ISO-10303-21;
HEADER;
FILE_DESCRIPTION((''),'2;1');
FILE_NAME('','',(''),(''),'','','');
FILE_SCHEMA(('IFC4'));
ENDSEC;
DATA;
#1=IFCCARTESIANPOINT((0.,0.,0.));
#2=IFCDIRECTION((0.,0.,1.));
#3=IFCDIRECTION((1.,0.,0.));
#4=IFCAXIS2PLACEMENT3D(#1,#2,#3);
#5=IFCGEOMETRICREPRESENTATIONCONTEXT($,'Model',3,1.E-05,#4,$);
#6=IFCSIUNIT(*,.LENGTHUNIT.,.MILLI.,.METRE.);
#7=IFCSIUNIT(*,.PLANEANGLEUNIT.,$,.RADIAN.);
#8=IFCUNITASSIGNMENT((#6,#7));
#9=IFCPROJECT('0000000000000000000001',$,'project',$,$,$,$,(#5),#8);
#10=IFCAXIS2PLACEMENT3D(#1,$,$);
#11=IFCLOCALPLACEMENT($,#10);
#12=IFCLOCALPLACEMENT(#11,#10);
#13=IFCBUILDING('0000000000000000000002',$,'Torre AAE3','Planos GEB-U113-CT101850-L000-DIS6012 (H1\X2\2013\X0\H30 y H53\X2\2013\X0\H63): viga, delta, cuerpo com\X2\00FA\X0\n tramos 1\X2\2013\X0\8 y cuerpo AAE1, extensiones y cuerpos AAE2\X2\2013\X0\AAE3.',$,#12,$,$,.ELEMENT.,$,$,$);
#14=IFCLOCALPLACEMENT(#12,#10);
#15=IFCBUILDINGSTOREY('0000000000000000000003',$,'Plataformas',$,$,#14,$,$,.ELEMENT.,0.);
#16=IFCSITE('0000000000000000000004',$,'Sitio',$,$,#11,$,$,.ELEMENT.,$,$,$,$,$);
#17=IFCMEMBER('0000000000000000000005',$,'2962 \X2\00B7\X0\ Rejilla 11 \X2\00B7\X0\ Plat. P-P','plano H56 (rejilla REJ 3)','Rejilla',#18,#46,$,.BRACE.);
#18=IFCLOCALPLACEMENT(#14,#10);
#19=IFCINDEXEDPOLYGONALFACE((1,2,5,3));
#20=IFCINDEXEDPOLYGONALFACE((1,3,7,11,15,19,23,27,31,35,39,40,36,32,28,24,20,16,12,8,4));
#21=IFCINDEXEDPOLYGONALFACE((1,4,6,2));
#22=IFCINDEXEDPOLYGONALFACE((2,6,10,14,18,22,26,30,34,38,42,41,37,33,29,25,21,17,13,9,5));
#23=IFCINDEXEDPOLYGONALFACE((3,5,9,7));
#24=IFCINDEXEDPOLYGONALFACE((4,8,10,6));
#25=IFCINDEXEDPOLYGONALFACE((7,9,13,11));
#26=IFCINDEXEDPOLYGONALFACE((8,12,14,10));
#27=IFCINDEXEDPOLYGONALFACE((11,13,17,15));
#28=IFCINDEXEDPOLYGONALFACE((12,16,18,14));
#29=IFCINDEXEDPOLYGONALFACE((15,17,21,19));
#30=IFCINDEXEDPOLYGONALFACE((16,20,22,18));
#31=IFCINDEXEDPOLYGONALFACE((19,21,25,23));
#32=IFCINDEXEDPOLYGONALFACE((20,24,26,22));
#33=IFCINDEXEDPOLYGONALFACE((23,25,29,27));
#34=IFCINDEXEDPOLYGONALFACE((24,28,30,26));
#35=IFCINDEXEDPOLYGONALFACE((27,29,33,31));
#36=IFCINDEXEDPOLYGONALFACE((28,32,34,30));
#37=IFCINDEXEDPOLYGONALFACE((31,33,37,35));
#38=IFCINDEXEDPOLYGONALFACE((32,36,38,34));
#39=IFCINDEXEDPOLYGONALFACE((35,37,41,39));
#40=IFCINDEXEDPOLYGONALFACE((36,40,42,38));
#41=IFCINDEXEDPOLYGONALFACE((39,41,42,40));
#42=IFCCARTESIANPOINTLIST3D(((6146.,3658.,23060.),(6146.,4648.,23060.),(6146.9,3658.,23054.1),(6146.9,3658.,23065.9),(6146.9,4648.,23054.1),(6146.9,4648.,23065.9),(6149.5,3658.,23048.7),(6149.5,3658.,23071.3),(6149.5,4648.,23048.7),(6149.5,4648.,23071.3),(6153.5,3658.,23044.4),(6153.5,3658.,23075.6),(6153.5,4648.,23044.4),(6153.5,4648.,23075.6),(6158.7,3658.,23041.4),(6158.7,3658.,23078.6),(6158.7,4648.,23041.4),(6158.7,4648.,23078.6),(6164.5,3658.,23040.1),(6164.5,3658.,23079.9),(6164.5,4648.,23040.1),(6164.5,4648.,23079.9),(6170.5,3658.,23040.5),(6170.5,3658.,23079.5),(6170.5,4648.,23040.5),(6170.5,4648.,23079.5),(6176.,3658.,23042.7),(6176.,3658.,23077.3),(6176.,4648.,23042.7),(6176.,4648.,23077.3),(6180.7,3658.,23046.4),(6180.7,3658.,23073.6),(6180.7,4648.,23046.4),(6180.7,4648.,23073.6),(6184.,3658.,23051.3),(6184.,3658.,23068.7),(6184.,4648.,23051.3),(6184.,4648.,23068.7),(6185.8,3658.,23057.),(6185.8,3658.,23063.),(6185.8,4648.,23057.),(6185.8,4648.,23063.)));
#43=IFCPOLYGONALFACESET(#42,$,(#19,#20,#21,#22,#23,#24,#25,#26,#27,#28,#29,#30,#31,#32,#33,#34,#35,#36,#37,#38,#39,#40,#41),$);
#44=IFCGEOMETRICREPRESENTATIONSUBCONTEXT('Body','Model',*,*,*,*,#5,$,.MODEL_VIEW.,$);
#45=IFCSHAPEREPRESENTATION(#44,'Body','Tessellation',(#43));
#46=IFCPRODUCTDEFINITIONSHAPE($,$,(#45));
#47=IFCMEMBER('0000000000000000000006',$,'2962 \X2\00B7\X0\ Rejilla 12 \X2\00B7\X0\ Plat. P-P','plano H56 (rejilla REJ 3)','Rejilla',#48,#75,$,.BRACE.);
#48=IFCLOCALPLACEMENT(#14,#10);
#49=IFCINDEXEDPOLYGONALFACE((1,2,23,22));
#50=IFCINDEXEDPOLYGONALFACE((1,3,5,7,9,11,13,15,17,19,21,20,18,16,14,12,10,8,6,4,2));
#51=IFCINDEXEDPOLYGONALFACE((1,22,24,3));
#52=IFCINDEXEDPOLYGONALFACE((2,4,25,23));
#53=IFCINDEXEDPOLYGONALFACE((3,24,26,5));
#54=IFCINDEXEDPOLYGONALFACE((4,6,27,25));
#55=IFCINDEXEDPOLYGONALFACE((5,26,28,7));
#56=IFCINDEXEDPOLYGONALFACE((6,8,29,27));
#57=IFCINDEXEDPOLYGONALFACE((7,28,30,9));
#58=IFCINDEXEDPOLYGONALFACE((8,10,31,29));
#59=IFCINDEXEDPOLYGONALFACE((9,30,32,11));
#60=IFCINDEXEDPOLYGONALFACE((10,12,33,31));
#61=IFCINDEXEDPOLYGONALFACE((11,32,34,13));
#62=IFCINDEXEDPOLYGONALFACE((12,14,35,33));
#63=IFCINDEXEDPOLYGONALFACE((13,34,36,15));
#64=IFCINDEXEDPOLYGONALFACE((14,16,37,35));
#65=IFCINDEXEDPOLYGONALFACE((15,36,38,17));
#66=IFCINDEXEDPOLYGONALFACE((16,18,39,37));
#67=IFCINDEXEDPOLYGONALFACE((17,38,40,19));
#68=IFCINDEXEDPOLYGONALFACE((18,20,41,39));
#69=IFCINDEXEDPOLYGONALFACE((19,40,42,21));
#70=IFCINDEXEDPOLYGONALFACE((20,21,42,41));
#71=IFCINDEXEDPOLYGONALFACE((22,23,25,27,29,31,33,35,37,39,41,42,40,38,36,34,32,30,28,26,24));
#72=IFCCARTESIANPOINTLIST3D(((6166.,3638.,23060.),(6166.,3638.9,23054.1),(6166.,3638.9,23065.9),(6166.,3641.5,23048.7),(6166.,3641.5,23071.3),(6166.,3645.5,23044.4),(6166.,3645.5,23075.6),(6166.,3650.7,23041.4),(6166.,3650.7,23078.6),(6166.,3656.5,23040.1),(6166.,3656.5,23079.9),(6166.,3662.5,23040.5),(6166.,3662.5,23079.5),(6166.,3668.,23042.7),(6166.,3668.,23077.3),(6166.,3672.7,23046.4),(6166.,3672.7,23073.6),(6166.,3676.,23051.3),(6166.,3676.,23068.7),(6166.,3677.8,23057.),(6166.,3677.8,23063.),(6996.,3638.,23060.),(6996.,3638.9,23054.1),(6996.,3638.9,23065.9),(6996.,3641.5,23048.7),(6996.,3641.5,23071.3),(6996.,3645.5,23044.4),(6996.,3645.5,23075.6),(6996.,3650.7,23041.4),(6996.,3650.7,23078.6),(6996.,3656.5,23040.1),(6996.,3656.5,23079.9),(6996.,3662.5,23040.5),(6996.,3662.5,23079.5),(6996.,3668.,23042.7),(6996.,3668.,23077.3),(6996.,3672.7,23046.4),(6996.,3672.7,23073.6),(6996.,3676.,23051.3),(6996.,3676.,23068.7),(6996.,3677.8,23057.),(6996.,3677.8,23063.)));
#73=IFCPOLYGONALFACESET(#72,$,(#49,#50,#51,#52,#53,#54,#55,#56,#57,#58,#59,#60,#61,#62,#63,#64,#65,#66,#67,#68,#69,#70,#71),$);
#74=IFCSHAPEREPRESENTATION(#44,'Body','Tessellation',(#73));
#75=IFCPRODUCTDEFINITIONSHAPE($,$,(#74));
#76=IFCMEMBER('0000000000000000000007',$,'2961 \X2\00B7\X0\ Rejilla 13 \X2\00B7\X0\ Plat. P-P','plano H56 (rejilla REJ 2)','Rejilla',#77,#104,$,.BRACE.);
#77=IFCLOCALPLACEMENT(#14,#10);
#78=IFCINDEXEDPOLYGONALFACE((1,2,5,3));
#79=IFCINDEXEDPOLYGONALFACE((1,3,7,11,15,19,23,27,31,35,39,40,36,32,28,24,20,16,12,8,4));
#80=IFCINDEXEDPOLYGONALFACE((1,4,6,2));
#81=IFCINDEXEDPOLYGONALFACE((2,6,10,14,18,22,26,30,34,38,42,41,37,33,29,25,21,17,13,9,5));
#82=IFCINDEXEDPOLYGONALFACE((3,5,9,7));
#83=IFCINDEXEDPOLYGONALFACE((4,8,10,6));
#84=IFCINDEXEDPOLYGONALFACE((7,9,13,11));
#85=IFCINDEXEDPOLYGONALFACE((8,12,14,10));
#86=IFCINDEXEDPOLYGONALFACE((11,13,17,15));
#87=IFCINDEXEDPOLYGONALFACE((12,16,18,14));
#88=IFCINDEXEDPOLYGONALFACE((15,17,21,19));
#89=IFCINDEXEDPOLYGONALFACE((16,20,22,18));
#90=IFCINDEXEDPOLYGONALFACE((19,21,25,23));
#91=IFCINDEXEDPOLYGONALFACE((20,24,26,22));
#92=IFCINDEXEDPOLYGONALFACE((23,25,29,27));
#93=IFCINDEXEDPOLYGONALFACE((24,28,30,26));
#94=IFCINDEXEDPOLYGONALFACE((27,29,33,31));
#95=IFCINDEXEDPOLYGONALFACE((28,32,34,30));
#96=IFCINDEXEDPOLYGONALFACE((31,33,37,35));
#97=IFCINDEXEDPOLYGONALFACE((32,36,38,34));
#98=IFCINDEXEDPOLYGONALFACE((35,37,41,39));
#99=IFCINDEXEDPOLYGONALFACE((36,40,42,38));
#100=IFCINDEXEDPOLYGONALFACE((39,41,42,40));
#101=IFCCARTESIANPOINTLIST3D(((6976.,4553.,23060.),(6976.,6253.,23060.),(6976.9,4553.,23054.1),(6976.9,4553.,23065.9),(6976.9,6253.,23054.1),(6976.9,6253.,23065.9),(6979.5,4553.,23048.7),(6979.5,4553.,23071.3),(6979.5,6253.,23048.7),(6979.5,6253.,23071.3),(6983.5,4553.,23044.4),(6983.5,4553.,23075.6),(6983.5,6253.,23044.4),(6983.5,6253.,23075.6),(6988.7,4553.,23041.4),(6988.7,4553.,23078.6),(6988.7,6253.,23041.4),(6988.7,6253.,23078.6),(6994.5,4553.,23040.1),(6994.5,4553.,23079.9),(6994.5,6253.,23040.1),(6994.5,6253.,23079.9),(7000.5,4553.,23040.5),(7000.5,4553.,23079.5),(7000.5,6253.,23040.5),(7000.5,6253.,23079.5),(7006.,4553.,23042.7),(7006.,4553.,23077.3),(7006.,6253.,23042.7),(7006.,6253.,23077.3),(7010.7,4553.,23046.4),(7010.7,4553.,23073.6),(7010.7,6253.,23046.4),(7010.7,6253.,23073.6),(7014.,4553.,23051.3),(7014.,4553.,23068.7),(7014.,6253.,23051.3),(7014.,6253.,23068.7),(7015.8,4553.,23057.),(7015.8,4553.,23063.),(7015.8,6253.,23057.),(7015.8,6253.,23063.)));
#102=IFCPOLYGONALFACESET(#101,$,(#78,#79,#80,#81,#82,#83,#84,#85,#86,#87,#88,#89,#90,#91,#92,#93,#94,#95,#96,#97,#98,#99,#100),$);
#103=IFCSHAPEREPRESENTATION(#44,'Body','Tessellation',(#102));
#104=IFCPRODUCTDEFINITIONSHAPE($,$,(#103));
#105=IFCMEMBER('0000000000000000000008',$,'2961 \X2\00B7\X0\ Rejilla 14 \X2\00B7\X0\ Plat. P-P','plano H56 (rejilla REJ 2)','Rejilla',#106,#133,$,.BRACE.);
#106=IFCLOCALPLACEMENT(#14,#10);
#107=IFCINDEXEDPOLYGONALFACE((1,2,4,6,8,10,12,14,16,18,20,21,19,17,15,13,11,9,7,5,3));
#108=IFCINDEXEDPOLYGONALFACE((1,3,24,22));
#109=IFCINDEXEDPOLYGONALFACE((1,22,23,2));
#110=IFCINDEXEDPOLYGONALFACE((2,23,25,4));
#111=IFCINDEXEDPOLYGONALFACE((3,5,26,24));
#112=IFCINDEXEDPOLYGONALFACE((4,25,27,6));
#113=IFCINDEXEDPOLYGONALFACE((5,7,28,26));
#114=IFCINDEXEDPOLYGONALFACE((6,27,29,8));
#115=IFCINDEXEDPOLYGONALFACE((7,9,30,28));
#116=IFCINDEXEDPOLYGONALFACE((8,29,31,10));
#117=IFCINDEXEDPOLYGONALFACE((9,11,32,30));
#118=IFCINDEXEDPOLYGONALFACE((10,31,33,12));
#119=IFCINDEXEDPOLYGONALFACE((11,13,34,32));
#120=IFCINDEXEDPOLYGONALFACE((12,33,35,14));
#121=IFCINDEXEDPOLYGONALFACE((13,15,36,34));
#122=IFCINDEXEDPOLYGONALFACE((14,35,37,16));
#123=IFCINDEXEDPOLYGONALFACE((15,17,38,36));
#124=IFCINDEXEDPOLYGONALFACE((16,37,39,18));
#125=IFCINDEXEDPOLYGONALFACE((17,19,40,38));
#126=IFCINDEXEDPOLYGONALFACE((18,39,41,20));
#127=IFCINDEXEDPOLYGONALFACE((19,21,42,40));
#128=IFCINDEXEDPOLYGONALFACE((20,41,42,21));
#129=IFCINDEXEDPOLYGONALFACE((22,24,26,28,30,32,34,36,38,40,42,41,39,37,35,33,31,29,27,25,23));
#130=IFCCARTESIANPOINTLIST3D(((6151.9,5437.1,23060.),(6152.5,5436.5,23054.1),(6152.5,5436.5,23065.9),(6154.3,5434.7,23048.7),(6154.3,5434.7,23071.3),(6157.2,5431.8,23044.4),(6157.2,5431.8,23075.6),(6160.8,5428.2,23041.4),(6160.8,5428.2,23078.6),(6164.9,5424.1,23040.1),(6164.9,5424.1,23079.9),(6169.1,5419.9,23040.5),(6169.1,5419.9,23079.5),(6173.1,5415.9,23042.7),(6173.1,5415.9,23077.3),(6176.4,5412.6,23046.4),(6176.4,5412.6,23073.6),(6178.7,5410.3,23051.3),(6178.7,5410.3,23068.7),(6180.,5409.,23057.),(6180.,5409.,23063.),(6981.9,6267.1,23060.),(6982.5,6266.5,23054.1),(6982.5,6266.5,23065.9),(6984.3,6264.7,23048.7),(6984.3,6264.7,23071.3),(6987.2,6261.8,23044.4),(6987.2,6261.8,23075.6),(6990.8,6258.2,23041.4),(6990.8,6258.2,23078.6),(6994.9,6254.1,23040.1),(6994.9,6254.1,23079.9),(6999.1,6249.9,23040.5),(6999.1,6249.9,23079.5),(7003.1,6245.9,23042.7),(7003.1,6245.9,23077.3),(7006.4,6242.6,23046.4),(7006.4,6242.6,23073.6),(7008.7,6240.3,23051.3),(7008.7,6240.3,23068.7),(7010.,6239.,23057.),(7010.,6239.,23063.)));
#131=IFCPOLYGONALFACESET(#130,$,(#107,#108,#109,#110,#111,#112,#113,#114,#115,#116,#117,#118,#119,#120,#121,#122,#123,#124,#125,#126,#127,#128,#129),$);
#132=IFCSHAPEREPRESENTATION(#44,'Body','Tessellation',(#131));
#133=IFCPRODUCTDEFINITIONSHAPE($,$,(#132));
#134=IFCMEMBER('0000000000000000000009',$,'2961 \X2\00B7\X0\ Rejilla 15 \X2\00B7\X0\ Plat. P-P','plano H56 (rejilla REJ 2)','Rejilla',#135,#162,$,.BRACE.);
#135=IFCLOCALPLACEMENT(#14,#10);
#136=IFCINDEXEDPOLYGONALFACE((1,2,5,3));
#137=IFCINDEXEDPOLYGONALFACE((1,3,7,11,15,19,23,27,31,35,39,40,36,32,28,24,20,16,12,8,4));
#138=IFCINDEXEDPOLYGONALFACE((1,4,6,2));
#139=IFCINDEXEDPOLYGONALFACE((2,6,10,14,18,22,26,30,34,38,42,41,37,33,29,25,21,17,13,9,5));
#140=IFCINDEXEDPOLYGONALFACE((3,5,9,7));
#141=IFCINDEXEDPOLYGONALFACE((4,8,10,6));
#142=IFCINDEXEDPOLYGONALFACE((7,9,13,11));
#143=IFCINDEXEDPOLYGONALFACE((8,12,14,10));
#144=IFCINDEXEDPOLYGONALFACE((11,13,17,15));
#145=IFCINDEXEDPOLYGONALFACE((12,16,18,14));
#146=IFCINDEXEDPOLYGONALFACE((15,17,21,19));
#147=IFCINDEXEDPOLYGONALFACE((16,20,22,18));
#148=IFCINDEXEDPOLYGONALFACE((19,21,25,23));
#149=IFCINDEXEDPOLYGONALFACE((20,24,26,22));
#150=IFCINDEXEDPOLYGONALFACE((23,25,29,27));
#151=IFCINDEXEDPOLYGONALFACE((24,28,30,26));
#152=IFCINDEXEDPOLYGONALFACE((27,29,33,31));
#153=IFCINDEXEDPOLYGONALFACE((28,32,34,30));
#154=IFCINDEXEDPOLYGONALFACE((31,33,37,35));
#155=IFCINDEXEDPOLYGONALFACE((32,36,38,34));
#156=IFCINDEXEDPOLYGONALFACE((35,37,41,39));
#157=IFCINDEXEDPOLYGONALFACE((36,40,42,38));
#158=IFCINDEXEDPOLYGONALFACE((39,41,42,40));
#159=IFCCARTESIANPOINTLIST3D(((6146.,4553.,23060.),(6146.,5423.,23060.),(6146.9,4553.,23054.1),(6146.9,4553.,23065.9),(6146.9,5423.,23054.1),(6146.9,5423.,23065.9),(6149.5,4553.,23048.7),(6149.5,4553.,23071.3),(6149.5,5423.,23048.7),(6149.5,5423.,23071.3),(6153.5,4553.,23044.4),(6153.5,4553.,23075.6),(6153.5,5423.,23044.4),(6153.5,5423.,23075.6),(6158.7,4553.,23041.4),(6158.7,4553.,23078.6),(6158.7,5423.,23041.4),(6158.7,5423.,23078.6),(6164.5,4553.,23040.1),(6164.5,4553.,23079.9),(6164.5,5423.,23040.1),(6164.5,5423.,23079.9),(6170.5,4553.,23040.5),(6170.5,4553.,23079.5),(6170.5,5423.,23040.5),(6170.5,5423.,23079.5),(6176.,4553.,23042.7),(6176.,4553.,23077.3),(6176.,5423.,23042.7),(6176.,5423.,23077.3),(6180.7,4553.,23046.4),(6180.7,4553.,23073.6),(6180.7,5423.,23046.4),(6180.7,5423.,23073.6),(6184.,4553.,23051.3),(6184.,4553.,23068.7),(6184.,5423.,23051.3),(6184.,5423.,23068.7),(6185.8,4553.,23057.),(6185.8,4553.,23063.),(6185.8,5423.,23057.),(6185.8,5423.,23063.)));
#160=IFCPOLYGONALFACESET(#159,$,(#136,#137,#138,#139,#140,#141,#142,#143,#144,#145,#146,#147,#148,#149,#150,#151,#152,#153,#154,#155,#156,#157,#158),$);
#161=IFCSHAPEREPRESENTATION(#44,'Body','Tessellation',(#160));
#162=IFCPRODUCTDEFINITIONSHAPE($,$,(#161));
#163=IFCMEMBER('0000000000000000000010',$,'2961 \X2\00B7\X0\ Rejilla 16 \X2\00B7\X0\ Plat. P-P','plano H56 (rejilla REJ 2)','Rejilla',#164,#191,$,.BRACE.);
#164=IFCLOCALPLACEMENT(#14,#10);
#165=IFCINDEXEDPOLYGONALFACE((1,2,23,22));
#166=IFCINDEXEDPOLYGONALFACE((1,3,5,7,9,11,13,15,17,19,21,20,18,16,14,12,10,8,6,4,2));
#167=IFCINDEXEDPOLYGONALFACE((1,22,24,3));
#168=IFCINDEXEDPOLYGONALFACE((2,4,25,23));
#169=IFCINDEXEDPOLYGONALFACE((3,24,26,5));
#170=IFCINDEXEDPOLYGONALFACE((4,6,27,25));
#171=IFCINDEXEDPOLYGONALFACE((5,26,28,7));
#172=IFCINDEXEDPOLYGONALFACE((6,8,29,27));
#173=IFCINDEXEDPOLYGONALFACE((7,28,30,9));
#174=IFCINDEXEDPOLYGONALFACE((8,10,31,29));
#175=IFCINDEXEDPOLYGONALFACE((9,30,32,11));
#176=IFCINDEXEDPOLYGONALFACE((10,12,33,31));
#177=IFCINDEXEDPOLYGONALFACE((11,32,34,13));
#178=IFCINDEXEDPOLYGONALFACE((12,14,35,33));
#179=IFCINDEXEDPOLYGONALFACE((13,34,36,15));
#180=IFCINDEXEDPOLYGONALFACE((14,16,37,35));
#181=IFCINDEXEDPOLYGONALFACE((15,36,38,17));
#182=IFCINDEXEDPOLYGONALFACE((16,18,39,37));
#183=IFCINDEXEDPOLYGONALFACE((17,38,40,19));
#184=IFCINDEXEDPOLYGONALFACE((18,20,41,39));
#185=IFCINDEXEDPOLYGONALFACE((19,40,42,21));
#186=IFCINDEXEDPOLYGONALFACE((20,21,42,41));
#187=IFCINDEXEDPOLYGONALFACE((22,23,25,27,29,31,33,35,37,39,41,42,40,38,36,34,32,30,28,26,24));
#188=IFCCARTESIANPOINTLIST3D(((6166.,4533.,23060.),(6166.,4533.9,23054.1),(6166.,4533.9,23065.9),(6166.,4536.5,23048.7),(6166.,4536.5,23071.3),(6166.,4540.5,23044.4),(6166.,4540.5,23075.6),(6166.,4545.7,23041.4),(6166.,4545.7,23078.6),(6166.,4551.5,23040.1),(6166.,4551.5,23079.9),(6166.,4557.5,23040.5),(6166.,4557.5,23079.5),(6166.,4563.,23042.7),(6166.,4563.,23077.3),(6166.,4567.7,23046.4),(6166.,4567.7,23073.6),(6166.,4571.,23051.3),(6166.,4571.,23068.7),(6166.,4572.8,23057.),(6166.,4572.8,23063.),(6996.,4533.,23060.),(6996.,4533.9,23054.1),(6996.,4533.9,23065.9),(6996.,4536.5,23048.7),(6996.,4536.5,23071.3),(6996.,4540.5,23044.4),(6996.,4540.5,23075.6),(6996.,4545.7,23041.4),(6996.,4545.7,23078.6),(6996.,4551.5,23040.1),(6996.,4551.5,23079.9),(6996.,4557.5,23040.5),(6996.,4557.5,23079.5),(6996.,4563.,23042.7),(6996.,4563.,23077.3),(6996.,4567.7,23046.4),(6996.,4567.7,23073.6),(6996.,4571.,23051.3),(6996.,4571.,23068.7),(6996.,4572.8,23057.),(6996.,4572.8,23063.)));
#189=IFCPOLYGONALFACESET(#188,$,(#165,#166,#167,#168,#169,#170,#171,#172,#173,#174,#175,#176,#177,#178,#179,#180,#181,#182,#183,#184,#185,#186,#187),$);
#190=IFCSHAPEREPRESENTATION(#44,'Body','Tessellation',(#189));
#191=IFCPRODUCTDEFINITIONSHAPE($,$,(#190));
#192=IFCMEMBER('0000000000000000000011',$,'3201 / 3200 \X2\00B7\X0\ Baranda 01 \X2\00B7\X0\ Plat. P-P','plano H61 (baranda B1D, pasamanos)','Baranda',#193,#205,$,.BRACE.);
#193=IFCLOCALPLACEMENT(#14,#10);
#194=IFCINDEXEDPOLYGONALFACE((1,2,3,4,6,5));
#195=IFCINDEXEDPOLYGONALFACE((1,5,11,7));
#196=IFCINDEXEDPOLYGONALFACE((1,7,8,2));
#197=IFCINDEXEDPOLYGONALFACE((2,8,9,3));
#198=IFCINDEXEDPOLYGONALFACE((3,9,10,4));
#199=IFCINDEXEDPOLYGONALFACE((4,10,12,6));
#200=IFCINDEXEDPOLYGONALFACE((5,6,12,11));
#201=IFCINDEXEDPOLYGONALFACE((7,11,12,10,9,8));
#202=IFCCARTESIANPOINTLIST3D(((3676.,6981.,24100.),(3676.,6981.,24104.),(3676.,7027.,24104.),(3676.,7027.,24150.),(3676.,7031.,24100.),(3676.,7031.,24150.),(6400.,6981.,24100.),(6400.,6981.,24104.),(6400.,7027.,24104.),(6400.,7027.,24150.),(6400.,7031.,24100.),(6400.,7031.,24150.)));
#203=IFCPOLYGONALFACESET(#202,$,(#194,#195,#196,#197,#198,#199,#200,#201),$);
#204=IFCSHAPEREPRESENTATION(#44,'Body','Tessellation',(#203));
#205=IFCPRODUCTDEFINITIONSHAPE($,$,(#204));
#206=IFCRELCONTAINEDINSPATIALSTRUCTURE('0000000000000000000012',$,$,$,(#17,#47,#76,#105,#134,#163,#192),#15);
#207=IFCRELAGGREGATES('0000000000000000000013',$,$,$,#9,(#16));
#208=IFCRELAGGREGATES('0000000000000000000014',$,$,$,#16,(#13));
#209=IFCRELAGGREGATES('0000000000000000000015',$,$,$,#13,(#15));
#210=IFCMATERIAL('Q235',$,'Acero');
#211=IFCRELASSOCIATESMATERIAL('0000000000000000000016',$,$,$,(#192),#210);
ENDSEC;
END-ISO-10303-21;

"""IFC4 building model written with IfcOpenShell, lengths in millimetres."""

from ifc_helpers import new_model, si_unit, frame, frame_2d, origin, origin_with_axes, place, context, subcontext, project, spatial, circle, l_section, extrude, material, element, save


model = new_model("IFC4")

# Units and contexts
model_context = context("Model", 3, precision=1e-05, world=origin_with_axes())
body_context = subcontext(model_context, "Body", "Model", "MODEL_VIEW")
ifc_project = project(units=[si_unit("LENGTHUNIT", "METRE", prefix="MILLI"), si_unit("PLANEANGLEUNIT", "RADIAN")], contexts=[model_context])

# Site, building, storey
site_placement = place(None, origin())
site = spatial("IfcSite", under=ifc_project, at=site_placement, Name="Sitio", CompositionType="ELEMENT")
building_placement = place(site_placement, origin())
building = spatial("IfcBuilding", under=site, at=building_placement, Name="Torre AAE3", Description="Planos GEB-U113-CT101850-L000-DIS6012 (H1–H30 y H53–H63): viga, delta, cuerpo común tramos 1–8 y cuerpo AAE1, extensiones y cuerpos AAE2–AAE3.", CompositionType="ELEMENT")
storey_placement = place(building_placement, origin())
storey = spatial("IfcBuildingStorey", under=building, at=storey_placement, Name="Plataformas", CompositionType="ELEMENT", Elevation=0.0)

# Members
member_1_placement = place(storey_placement, frame((6166.0, 4648.0, 23060.0), z_axis=(0.0, -1.0, 0.0), x_axis=(-1.0, 0.0, 0.0)))
element("IfcMember", 1, at=member_1_placement, inside=storey, Name="2962 · Rejilla 11 · Plat. P-P", Description="plano H56 (rejilla REJ 3)", ObjectType="Rejilla", PredefinedType="BRACE", context=body_context, shape_type="SweptSolid", body=[
    extrude(circle(Radius=20.0), None, (0.0, 0.0, 1.0), 990.0),
])
member_2_placement = place(storey_placement, frame((6166.0, 3658.0, 23060.0), z_axis=(1.0, 0.0, 0.0), x_axis=(0.0, -1.0, 0.0)))
element("IfcMember", 2, at=member_2_placement, inside=storey, Name="2962 · Rejilla 12 · Plat. P-P", Description="plano H56 (rejilla REJ 3)", ObjectType="Rejilla", PredefinedType="BRACE", context=body_context, shape_type="SweptSolid", body=[
    extrude(circle(Radius=20.0), None, (0.0, 0.0, 1.0), 830.0),
])
member_3_placement = place(storey_placement, frame((6996.0, 4553.0, 23060.0), z_axis=(0.0, 1.0, 0.0), x_axis=(-1.0, 0.0, 0.0)))
element("IfcMember", 3, at=member_3_placement, inside=storey, Name="2961 · Rejilla 13 · Plat. P-P", Description="plano H56 (rejilla REJ 2)", ObjectType="Rejilla", PredefinedType="BRACE", context=body_context, shape_type="SweptSolid", body=[
    extrude(circle(Radius=20.0), None, (0.0, 0.0, 1.0), 1700.0),
])
member_4_placement = place(storey_placement, frame((6996.0, 6253.0, 23060.0), z_axis=(-0.707107, -0.707107, 0.0), x_axis=(-0.707107, 0.707107, 0.0)))
element("IfcMember", 4, at=member_4_placement, inside=storey, Name="2961 · Rejilla 14 · Plat. P-P", Description="plano H56 (rejilla REJ 2)", ObjectType="Rejilla", PredefinedType="BRACE", context=body_context, shape_type="SweptSolid", body=[
    extrude(circle(Radius=20.0), None, (0.0, 0.0, 1.0), 1173.8),
])
member_5_placement = place(storey_placement, frame((6166.0, 5423.0, 23060.0), z_axis=(0.0, -1.0, 0.0), x_axis=(-1.0, 0.0, 0.0)))
element("IfcMember", 5, at=member_5_placement, inside=storey, Name="2961 · Rejilla 15 · Plat. P-P", Description="plano H56 (rejilla REJ 2)", ObjectType="Rejilla", PredefinedType="BRACE", context=body_context, shape_type="SweptSolid", body=[
    extrude(circle(Radius=20.0), None, (0.0, 0.0, 1.0), 870.0),
])
member_6_placement = place(storey_placement, frame((6166.0, 4553.0, 23060.0), z_axis=(1.0, 0.0, 0.0), x_axis=(0.0, -1.0, 0.0)))
element("IfcMember", 6, at=member_6_placement, inside=storey, Name="2961 · Rejilla 16 · Plat. P-P", Description="plano H56 (rejilla REJ 2)", ObjectType="Rejilla", PredefinedType="BRACE", context=body_context, shape_type="SweptSolid", body=[
    extrude(circle(Radius=20.0), None, (0.0, 0.0, 1.0), 830.0),
])
ifc_material = material(Name="Q235", Category="Acero")
member_7_placement = place(storey_placement, frame((6400.0, 7031.0, 24100.0), z_axis=(-1.0, 0.0, 0.0), x_axis=(0.0, -1.0, 0.0)))
element("IfcMember", 7, at=member_7_placement, inside=storey, material=ifc_material, Name="3201 / 3200 · Baranda 01 · Plat. P-P", Description="plano H61 (baranda B1D, pasamanos)", ObjectType="Baranda", PredefinedType="BRACE", context=body_context, shape_type="SweptSolid", body=[
    extrude(l_section(Depth=50.0, Width=50.0, Thickness=4.0, at=frame_2d((25.0, 25.0))), None, (0.0, 0.0, 1.0), 2724.0),
])

save(model, "model.ifc")
